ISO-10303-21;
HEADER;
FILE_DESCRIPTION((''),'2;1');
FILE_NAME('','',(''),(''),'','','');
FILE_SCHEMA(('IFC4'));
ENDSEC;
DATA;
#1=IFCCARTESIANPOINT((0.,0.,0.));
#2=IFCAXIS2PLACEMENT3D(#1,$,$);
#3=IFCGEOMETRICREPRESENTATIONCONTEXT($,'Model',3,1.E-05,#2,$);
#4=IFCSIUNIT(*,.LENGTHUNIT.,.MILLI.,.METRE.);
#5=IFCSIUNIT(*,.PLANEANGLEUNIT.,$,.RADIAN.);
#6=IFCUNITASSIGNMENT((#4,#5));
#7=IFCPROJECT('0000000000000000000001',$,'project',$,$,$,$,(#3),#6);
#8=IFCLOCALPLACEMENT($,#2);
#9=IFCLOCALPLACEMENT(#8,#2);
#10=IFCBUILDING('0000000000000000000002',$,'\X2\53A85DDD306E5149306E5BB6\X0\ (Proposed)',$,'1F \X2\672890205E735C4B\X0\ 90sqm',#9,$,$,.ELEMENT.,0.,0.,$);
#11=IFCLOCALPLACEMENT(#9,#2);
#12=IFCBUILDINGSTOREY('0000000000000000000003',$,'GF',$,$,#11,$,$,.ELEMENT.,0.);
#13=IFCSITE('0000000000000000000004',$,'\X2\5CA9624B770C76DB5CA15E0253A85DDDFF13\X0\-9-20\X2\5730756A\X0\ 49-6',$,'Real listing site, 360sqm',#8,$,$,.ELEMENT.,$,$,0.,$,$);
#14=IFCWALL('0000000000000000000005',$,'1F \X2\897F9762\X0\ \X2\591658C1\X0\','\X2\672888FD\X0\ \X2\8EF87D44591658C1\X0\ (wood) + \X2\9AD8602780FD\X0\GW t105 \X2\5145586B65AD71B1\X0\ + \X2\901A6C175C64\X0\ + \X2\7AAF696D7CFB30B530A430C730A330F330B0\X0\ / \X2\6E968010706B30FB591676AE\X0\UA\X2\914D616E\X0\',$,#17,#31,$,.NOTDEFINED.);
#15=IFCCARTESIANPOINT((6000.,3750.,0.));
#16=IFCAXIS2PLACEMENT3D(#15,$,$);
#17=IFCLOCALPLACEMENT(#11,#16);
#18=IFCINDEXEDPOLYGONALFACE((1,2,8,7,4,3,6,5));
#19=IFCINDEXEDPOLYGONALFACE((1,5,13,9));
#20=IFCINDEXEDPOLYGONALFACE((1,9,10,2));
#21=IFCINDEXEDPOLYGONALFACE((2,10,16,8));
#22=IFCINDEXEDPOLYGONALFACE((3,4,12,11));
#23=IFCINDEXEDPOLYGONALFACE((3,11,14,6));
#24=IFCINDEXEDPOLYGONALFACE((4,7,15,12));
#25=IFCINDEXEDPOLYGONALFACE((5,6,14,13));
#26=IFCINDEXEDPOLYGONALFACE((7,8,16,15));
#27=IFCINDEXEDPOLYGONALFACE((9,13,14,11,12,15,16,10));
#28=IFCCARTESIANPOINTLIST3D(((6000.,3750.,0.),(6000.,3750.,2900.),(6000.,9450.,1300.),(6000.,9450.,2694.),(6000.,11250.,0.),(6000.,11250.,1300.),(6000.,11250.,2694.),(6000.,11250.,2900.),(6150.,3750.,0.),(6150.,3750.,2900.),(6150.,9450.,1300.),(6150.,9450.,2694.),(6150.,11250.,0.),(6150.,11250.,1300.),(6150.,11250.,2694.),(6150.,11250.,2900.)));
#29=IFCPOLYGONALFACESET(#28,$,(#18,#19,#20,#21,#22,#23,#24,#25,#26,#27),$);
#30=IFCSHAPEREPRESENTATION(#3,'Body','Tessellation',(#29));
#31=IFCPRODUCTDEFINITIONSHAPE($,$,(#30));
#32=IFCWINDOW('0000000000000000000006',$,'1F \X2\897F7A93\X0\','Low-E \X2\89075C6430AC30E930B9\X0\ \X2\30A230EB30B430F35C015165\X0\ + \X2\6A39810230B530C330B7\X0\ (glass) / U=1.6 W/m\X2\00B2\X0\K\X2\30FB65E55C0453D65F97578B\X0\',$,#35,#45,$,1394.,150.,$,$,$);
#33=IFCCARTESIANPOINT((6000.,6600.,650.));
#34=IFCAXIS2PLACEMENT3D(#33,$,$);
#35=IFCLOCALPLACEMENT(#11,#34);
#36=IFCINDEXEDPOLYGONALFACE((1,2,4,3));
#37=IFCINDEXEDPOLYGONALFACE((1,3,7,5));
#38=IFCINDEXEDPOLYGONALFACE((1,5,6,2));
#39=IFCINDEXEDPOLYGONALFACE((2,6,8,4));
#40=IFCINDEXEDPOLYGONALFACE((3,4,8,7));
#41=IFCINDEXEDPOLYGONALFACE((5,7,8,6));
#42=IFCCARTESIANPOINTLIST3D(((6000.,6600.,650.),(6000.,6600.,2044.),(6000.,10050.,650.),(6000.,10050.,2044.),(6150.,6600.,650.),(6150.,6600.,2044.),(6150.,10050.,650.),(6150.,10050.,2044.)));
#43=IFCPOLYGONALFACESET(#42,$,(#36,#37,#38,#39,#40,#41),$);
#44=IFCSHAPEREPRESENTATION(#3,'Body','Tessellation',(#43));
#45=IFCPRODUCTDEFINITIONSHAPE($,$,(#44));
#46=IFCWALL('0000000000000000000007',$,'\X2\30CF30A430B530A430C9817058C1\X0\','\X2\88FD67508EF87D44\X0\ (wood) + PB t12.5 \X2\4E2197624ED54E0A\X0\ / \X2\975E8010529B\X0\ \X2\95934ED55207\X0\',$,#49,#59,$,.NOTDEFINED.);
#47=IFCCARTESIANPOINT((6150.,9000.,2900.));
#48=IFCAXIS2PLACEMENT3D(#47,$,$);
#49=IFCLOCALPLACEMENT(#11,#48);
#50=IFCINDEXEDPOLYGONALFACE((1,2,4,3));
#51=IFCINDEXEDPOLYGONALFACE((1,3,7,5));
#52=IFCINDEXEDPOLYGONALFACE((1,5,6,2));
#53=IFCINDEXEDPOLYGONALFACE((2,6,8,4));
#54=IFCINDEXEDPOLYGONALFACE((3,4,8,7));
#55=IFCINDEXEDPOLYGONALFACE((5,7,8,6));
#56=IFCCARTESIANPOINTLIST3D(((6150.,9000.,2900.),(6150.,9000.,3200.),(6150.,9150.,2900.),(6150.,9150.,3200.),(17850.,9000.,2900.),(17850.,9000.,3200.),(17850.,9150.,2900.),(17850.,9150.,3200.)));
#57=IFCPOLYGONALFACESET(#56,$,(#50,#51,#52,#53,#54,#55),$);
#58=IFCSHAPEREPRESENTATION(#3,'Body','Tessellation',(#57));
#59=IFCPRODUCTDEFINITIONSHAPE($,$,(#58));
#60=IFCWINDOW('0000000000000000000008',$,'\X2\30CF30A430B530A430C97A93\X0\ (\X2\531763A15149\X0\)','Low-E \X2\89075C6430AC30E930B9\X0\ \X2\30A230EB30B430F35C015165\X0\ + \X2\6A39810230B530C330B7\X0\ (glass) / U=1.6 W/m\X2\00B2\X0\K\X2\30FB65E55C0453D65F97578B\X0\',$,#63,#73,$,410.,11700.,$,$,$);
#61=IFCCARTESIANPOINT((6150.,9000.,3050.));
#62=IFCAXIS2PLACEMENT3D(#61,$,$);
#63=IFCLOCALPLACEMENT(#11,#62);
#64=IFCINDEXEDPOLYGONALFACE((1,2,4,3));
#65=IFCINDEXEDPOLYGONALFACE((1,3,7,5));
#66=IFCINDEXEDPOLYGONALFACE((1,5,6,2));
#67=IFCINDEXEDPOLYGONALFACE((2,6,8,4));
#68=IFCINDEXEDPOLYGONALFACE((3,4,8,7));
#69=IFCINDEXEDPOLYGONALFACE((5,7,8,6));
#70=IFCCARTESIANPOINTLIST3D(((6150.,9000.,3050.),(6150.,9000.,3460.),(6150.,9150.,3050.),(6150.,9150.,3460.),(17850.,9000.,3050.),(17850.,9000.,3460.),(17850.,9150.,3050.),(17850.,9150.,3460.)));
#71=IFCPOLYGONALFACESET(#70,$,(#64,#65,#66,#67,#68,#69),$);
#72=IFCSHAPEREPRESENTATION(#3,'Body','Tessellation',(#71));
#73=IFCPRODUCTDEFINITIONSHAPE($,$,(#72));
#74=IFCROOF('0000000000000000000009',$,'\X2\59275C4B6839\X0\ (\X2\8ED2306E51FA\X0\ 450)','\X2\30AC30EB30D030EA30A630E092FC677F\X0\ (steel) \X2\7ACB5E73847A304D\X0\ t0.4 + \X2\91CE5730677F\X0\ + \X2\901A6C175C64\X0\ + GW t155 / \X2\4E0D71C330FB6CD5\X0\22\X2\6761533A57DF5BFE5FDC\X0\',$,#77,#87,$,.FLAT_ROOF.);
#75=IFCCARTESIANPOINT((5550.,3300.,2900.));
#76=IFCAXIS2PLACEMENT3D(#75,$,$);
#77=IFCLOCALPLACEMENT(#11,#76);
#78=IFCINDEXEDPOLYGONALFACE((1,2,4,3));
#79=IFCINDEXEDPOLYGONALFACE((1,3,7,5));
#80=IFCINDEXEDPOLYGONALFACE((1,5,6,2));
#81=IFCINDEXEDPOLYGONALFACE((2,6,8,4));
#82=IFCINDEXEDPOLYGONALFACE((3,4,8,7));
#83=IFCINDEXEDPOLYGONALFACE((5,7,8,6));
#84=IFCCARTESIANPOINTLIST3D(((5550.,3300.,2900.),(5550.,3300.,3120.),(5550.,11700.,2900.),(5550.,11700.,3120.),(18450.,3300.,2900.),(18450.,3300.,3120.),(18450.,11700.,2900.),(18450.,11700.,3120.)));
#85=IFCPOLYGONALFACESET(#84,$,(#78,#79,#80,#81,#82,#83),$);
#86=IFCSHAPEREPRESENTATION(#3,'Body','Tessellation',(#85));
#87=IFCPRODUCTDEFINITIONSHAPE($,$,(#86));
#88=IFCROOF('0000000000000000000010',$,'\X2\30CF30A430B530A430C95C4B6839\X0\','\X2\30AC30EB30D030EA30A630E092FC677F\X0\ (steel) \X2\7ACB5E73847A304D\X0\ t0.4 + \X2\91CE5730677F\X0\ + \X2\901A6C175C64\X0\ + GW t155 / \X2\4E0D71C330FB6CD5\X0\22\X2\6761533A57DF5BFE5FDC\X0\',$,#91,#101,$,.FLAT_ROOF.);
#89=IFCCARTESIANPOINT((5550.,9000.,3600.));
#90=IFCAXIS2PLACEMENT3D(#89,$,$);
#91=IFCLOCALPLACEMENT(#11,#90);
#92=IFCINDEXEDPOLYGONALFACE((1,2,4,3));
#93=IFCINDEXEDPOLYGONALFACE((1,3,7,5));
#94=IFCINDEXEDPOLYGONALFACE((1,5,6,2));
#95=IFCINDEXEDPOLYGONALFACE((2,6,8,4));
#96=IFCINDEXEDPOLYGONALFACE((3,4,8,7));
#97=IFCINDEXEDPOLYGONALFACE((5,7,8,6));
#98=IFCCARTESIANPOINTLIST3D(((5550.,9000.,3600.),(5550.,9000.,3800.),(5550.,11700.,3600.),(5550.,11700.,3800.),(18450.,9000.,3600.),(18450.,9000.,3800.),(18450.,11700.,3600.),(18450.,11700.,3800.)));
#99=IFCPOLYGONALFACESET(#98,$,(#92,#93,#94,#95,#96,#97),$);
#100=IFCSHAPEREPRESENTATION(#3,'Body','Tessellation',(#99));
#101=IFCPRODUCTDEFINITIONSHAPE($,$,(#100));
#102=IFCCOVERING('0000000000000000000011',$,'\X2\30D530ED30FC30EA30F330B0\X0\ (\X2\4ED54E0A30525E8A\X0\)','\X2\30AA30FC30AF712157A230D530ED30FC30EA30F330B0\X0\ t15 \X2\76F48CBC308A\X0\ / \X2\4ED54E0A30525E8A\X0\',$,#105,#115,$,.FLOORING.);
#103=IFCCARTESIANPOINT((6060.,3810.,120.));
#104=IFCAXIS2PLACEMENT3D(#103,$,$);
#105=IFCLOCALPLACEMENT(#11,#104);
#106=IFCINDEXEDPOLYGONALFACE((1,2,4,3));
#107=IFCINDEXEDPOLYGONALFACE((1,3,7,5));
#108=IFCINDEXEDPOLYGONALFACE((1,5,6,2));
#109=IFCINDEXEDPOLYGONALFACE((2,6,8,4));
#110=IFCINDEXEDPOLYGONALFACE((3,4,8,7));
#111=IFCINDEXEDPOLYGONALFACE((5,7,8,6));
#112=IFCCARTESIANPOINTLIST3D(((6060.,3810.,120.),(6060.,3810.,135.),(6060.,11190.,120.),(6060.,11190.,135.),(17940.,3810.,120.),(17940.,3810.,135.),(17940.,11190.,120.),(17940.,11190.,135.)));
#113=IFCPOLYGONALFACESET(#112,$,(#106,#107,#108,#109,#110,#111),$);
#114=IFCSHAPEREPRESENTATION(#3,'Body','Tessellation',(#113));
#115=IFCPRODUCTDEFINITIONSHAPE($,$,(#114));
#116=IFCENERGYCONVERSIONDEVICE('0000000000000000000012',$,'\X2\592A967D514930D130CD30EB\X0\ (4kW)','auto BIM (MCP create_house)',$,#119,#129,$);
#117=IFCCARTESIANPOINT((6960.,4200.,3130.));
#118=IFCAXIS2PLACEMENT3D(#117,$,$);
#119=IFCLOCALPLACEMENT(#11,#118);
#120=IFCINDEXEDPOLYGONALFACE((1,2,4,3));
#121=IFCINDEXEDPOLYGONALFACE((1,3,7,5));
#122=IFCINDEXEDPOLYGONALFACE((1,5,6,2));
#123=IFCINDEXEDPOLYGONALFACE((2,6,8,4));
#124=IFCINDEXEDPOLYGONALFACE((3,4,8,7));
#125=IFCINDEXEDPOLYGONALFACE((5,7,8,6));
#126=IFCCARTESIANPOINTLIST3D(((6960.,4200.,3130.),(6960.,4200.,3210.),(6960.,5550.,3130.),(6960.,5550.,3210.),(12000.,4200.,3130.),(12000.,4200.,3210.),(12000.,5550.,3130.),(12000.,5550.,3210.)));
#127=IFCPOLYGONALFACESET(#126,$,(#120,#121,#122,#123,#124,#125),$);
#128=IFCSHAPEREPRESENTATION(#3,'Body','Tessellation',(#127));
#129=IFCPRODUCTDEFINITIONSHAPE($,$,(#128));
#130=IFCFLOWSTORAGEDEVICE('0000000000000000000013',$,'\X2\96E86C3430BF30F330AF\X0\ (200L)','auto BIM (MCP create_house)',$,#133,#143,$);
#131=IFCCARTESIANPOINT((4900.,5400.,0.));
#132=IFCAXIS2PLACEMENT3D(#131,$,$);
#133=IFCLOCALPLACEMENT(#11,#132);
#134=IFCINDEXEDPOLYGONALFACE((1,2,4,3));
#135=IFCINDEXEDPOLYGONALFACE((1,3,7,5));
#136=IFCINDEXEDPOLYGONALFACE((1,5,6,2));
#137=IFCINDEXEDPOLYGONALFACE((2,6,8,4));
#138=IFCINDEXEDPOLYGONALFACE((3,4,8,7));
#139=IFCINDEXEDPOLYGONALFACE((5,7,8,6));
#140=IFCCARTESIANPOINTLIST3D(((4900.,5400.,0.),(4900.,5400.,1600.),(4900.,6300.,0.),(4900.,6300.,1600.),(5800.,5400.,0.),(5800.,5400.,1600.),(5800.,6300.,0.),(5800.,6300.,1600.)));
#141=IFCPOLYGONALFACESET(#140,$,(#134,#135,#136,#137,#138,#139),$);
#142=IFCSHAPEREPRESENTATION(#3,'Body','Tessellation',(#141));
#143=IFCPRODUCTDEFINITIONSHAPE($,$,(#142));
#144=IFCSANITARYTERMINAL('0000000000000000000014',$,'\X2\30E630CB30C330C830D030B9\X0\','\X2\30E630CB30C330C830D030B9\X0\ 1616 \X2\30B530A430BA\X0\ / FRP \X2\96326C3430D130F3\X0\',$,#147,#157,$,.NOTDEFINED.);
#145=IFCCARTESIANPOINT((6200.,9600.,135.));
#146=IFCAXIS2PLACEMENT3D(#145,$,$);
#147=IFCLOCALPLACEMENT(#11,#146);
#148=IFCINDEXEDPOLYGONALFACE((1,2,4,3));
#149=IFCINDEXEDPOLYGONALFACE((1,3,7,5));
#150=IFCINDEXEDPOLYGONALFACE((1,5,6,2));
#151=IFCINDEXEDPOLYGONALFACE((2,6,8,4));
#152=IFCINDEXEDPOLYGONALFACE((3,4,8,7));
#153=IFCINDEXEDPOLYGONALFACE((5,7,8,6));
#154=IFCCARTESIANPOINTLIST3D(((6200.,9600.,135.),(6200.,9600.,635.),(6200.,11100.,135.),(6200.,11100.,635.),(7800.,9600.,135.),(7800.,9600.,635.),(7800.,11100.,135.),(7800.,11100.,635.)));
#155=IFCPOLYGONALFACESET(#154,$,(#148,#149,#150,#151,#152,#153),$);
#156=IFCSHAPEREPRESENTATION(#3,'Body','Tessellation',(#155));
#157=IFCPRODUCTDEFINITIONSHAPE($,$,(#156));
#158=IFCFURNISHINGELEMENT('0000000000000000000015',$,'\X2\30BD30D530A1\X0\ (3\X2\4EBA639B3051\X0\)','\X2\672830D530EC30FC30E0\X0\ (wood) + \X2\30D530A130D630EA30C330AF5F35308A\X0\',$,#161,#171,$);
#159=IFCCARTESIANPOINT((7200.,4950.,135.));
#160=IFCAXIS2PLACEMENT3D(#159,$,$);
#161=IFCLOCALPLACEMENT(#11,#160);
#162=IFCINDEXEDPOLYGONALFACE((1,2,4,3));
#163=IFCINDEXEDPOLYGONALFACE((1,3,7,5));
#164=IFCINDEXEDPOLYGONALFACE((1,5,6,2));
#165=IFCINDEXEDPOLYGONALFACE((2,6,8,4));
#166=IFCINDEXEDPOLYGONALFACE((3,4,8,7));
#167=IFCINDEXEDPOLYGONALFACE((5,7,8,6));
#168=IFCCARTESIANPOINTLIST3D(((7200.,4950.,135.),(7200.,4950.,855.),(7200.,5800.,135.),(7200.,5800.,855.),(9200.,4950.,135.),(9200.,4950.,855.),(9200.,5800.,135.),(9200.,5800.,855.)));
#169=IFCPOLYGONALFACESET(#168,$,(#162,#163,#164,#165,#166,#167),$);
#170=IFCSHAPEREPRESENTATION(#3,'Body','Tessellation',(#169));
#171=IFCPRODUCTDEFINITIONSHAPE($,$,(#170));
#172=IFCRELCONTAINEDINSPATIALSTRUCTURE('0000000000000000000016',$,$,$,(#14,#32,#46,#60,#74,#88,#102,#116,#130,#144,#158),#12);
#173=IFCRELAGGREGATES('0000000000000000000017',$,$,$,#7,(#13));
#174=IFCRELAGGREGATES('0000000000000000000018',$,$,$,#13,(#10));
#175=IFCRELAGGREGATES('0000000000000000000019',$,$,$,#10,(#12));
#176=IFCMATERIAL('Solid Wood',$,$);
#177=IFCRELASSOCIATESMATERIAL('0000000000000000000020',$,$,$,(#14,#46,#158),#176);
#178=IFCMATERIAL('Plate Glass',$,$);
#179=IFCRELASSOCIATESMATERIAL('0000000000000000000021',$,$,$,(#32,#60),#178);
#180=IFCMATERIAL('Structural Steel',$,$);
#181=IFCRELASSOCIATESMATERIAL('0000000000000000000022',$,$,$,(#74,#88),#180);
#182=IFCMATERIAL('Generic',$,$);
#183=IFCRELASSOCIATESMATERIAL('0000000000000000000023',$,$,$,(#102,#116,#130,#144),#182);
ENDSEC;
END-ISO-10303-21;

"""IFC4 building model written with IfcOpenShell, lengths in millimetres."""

from ifc_helpers import new_model, si_unit, frame, frame_2d, origin, place, context, project, spatial, rectangle, extrude, material, element, fill, save


model = new_model("IFC4")

# Units and contexts
model_context = context("Model", 3, precision=1e-05, world=origin())
ifc_project = project(units=[si_unit("LENGTHUNIT", "METRE", prefix="MILLI"), si_unit("PLANEANGLEUNIT", "RADIAN")], contexts=[model_context])

# Site, building, storey
site_placement = place(None, origin())
site = spatial("IfcSite", under=ifc_project, at=site_placement, Name="岩手県盛岡市厨川３-9-20地番 49-6", ObjectType="Real listing site, 360sqm", CompositionType="ELEMENT", RefElevation=0.0)
building_placement = place(site_placement, origin())
building = spatial("IfcBuilding", under=site, at=building_placement, Name="厨川の光の家 (Proposed)", ObjectType="1F 木造平屋 90sqm", CompositionType="ELEMENT", ElevationOfRefHeight=0.0, ElevationOfTerrain=0.0)
storey_placement = place(building_placement, origin())
storey = spatial("IfcBuildingStorey", under=building, at=storey_placement, Name="GF", CompositionType="ELEMENT", Elevation=0.0)

# Shared definitions
ifc_material_1 = material(Name="Solid Wood")

# Shared definitions
ifc_material_2 = material(Name="Plate Glass")

# Wall, opening, window
wall_1_placement = place(storey_placement, frame((6000.0, 3750.0, 0.0)))
wall_1 = element("IfcWall", 1, at=wall_1_placement, inside=storey, material=ifc_material_1, Name="1F 西面 外壁", Description="木製 軸組外壁 (wood) + 高性能GW t105 充填断熱 + 通気層 + 窯業系サイディング / 準耐火・外皮UA配慮", PredefinedType="NOTDEFINED", context=model_context, shape_type="SweptSolid", body=[
    extrude(rectangle(XDim=150.0, YDim=7500.0, at=frame_2d((75.0, 3750.0))), frame((6000.0, 3750.0, 0.0)), (0.0, 0.0, 1.0), 2900.0),
])
opening_1_placement = place(storey_placement, frame((6000.0, 6600.0, 650.0)))
opening_1 = element("IfcOpeningElement", 2, at=opening_1_placement, cuts=wall_1, PredefinedType="NOTDEFINED", context=model_context, shape_type="SweptSolid", body=[
    extrude(rectangle(XDim=150.0, YDim=3450.0, at=frame_2d((75.0, 1725.0))), frame((6000.0, 6600.0, 650.0)), (0.0, 0.0, 1.0), 1394.0),
])
window_1_placement = place(storey_placement, frame((6000.0, 6600.0, 650.0)))
window_1 = element("IfcWindow", 3, at=window_1_placement, inside=storey, material=ifc_material_2, Name="1F 西窓", Description="Low-E 複層ガラス アルゴン封入 + 樹脂サッシ (glass) / U=1.6 W/m²K・日射取得型", OverallHeight=1394.0, OverallWidth=150.0, context=model_context, shape_type="SweptSolid", body=[
    extrude(rectangle(XDim=150.0, YDim=3450.0, at=frame_2d((75.0, 1725.0))), frame((6000.0, 6600.0, 650.0)), (0.0, 0.0, 1.0), 1394.0),
])
fill(opening_1, window_1)

# Wall, opening, window
wall_2_placement = place(storey_placement, frame((6150.0, 9000.0, 2900.0)))
wall_2 = element("IfcWall", 4, at=wall_2_placement, inside=storey, material=ifc_material_1, Name="ハイサイド腰壁", Description="製材軸組 (wood) + PB t12.5 両面仕上 / 非耐力 間仕切", PredefinedType="NOTDEFINED", context=model_context, shape_type="SweptSolid", body=[
    extrude(rectangle(XDim=11700.0, YDim=150.0, at=frame_2d((5850.0, 75.0))), frame((6150.0, 9000.0, 2900.0)), (0.0, 0.0, 1.0), 700.0),
])
opening_2_placement = place(storey_placement, frame((6150.0, 9000.0, 3050.0)))
opening_2 = element("IfcOpeningElement", 5, at=opening_2_placement, cuts=wall_2, PredefinedType="NOTDEFINED", context=model_context, shape_type="SweptSolid", body=[
    extrude(rectangle(XDim=11700.0, YDim=150.0, at=frame_2d((5850.0, 75.0))), frame((6150.0, 9000.0, 3050.0)), (0.0, 0.0, 1.0), 410.0),
])
window_2_placement = place(storey_placement, frame((6150.0, 9000.0, 3050.0)))
window_2 = element("IfcWindow", 6, at=window_2_placement, inside=storey, material=ifc_material_2, Name="ハイサイド窓 (北採光)", Description="Low-E 複層ガラス アルゴン封入 + 樹脂サッシ (glass) / U=1.6 W/m²K・日射取得型", OverallHeight=410.0, OverallWidth=11700.0, context=model_context, shape_type="SweptSolid", body=[
    extrude(rectangle(XDim=11700.0, YDim=150.0, at=frame_2d((5850.0, 75.0))), frame((6150.0, 9000.0, 3050.0)), (0.0, 0.0, 1.0), 410.0),
])
fill(opening_2, window_2)

# Roofs
ifc_material_3 = material(Name="Structural Steel")
roof_1_placement = place(storey_placement, frame((5550.0, 3300.0, 2900.0)))
element("IfcRoof", 7, at=roof_1_placement, inside=storey, material=ifc_material_3, Name="大屋根 (軒の出 450)", Description="ガルバリウム鋼板 (steel) 立平葺き t0.4 + 野地板 + 通気層 + GW t155 / 不燃・法22条区域対応", PredefinedType="FLAT_ROOF", context=model_context, shape_type="SweptSolid", body=[
    extrude(rectangle(XDim=12900.0, YDim=8400.0, at=frame_2d((6450.0, 4200.0))), frame((5550.0, 3300.0, 2900.0)), (0.0, 0.0, 1.0), 220.0),
])
roof_2_placement = place(storey_placement, frame((5550.0, 9000.0, 3600.0)))
element("IfcRoof", 8, at=roof_2_placement, inside=storey, material=ifc_material_3, Name="ハイサイド屋根", Description="ガルバリウム鋼板 (steel) 立平葺き t0.4 + 野地板 + 通気層 + GW t155 / 不燃・法22条区域対応", PredefinedType="FLAT_ROOF", context=model_context, shape_type="SweptSolid", body=[
    extrude(rectangle(XDim=12900.0, YDim=2700.0, at=frame_2d((6450.0, 1350.0))), frame((5550.0, 9000.0, 3600.0)), (0.0, 0.0, 1.0), 200.0),
])

# Covering
ifc_material_4 = material(Name="Generic")
covering_placement = place(storey_placement, frame((6060.0, 3810.0, 120.0)))
element("IfcCovering", 9, at=covering_placement, inside=storey, material=ifc_material_4, Name="フローリング (仕上げ床)", Description="オーク無垢フローリング t15 直貼り / 仕上げ床", PredefinedType="FLOORING", context=model_context, shape_type="SweptSolid", body=[
    extrude(rectangle(XDim=11880.0, YDim=7380.0, at=frame_2d((5940.0, 3690.0))), frame((6060.0, 3810.0, 120.0)), (0.0, 0.0, 1.0), 15.0),
])

# Energy conversion device
energy_conversion_device_placement = place(storey_placement, frame((6960.0, 4200.0, 3130.0)))
element("IfcEnergyConversionDevice", 10, at=energy_conversion_device_placement, inside=storey, material=ifc_material_4, Name="太陽光パネル (4kW)", Description="auto BIM (MCP create_house)", context=model_context, shape_type="SweptSolid", body=[
    extrude(rectangle(XDim=5040.0, YDim=1350.0, at=frame_2d((2520.0, 675.0))), frame((6960.0, 4200.0, 3130.0)), (0.0, 0.0, 1.0), 80.0),
])

# Flow storage device
flow_storage_device_placement = place(storey_placement, frame((4900.0, 5400.0, 0.0)))
element("IfcFlowStorageDevice", 11, at=flow_storage_device_placement, inside=storey, material=ifc_material_4, Name="雨水タンク (200L)", Description="auto BIM (MCP create_house)", context=model_context, shape_type="SweptSolid", body=[
    extrude(rectangle(XDim=900.0, YDim=900.0, at=frame_2d((450.0, 450.0))), frame((4900.0, 5400.0, 0.0)), (0.0, 0.0, 1.0), 1600.0),
])

# Sanitary terminal
sanitary_terminal_placement = place(storey_placement, frame((6200.0, 9600.0, 135.0)))
element("IfcSanitaryTerminal", 12, at=sanitary_terminal_placement, inside=storey, material=ifc_material_4, Name="ユニットバス", Description="ユニットバス 1616 サイズ / FRP 防水パン", PredefinedType="NOTDEFINED", context=model_context, shape_type="SweptSolid", body=[
    extrude(rectangle(XDim=1600.0, YDim=1500.0, at=frame_2d((800.0, 750.0))), frame((6200.0, 9600.0, 135.0)), (0.0, 0.0, 1.0), 500.0),
])

# Furnishing element
furnishing_placement = place(storey_placement, frame((7200.0, 4950.0, 135.0)))
element("IfcFurnishingElement", 13, at=furnishing_placement, inside=storey, material=ifc_material_1, Name="ソファ (3人掛け)", Description="木フレーム (wood) + ファブリック張り", context=model_context, shape_type="SweptSolid", body=[
    extrude(rectangle(XDim=2000.0, YDim=850.0, at=frame_2d((1000.0, 425.0))), frame((7200.0, 4950.0, 135.0)), (0.0, 0.0, 1.0), 720.0),
])

save(model, "model.ifc")
